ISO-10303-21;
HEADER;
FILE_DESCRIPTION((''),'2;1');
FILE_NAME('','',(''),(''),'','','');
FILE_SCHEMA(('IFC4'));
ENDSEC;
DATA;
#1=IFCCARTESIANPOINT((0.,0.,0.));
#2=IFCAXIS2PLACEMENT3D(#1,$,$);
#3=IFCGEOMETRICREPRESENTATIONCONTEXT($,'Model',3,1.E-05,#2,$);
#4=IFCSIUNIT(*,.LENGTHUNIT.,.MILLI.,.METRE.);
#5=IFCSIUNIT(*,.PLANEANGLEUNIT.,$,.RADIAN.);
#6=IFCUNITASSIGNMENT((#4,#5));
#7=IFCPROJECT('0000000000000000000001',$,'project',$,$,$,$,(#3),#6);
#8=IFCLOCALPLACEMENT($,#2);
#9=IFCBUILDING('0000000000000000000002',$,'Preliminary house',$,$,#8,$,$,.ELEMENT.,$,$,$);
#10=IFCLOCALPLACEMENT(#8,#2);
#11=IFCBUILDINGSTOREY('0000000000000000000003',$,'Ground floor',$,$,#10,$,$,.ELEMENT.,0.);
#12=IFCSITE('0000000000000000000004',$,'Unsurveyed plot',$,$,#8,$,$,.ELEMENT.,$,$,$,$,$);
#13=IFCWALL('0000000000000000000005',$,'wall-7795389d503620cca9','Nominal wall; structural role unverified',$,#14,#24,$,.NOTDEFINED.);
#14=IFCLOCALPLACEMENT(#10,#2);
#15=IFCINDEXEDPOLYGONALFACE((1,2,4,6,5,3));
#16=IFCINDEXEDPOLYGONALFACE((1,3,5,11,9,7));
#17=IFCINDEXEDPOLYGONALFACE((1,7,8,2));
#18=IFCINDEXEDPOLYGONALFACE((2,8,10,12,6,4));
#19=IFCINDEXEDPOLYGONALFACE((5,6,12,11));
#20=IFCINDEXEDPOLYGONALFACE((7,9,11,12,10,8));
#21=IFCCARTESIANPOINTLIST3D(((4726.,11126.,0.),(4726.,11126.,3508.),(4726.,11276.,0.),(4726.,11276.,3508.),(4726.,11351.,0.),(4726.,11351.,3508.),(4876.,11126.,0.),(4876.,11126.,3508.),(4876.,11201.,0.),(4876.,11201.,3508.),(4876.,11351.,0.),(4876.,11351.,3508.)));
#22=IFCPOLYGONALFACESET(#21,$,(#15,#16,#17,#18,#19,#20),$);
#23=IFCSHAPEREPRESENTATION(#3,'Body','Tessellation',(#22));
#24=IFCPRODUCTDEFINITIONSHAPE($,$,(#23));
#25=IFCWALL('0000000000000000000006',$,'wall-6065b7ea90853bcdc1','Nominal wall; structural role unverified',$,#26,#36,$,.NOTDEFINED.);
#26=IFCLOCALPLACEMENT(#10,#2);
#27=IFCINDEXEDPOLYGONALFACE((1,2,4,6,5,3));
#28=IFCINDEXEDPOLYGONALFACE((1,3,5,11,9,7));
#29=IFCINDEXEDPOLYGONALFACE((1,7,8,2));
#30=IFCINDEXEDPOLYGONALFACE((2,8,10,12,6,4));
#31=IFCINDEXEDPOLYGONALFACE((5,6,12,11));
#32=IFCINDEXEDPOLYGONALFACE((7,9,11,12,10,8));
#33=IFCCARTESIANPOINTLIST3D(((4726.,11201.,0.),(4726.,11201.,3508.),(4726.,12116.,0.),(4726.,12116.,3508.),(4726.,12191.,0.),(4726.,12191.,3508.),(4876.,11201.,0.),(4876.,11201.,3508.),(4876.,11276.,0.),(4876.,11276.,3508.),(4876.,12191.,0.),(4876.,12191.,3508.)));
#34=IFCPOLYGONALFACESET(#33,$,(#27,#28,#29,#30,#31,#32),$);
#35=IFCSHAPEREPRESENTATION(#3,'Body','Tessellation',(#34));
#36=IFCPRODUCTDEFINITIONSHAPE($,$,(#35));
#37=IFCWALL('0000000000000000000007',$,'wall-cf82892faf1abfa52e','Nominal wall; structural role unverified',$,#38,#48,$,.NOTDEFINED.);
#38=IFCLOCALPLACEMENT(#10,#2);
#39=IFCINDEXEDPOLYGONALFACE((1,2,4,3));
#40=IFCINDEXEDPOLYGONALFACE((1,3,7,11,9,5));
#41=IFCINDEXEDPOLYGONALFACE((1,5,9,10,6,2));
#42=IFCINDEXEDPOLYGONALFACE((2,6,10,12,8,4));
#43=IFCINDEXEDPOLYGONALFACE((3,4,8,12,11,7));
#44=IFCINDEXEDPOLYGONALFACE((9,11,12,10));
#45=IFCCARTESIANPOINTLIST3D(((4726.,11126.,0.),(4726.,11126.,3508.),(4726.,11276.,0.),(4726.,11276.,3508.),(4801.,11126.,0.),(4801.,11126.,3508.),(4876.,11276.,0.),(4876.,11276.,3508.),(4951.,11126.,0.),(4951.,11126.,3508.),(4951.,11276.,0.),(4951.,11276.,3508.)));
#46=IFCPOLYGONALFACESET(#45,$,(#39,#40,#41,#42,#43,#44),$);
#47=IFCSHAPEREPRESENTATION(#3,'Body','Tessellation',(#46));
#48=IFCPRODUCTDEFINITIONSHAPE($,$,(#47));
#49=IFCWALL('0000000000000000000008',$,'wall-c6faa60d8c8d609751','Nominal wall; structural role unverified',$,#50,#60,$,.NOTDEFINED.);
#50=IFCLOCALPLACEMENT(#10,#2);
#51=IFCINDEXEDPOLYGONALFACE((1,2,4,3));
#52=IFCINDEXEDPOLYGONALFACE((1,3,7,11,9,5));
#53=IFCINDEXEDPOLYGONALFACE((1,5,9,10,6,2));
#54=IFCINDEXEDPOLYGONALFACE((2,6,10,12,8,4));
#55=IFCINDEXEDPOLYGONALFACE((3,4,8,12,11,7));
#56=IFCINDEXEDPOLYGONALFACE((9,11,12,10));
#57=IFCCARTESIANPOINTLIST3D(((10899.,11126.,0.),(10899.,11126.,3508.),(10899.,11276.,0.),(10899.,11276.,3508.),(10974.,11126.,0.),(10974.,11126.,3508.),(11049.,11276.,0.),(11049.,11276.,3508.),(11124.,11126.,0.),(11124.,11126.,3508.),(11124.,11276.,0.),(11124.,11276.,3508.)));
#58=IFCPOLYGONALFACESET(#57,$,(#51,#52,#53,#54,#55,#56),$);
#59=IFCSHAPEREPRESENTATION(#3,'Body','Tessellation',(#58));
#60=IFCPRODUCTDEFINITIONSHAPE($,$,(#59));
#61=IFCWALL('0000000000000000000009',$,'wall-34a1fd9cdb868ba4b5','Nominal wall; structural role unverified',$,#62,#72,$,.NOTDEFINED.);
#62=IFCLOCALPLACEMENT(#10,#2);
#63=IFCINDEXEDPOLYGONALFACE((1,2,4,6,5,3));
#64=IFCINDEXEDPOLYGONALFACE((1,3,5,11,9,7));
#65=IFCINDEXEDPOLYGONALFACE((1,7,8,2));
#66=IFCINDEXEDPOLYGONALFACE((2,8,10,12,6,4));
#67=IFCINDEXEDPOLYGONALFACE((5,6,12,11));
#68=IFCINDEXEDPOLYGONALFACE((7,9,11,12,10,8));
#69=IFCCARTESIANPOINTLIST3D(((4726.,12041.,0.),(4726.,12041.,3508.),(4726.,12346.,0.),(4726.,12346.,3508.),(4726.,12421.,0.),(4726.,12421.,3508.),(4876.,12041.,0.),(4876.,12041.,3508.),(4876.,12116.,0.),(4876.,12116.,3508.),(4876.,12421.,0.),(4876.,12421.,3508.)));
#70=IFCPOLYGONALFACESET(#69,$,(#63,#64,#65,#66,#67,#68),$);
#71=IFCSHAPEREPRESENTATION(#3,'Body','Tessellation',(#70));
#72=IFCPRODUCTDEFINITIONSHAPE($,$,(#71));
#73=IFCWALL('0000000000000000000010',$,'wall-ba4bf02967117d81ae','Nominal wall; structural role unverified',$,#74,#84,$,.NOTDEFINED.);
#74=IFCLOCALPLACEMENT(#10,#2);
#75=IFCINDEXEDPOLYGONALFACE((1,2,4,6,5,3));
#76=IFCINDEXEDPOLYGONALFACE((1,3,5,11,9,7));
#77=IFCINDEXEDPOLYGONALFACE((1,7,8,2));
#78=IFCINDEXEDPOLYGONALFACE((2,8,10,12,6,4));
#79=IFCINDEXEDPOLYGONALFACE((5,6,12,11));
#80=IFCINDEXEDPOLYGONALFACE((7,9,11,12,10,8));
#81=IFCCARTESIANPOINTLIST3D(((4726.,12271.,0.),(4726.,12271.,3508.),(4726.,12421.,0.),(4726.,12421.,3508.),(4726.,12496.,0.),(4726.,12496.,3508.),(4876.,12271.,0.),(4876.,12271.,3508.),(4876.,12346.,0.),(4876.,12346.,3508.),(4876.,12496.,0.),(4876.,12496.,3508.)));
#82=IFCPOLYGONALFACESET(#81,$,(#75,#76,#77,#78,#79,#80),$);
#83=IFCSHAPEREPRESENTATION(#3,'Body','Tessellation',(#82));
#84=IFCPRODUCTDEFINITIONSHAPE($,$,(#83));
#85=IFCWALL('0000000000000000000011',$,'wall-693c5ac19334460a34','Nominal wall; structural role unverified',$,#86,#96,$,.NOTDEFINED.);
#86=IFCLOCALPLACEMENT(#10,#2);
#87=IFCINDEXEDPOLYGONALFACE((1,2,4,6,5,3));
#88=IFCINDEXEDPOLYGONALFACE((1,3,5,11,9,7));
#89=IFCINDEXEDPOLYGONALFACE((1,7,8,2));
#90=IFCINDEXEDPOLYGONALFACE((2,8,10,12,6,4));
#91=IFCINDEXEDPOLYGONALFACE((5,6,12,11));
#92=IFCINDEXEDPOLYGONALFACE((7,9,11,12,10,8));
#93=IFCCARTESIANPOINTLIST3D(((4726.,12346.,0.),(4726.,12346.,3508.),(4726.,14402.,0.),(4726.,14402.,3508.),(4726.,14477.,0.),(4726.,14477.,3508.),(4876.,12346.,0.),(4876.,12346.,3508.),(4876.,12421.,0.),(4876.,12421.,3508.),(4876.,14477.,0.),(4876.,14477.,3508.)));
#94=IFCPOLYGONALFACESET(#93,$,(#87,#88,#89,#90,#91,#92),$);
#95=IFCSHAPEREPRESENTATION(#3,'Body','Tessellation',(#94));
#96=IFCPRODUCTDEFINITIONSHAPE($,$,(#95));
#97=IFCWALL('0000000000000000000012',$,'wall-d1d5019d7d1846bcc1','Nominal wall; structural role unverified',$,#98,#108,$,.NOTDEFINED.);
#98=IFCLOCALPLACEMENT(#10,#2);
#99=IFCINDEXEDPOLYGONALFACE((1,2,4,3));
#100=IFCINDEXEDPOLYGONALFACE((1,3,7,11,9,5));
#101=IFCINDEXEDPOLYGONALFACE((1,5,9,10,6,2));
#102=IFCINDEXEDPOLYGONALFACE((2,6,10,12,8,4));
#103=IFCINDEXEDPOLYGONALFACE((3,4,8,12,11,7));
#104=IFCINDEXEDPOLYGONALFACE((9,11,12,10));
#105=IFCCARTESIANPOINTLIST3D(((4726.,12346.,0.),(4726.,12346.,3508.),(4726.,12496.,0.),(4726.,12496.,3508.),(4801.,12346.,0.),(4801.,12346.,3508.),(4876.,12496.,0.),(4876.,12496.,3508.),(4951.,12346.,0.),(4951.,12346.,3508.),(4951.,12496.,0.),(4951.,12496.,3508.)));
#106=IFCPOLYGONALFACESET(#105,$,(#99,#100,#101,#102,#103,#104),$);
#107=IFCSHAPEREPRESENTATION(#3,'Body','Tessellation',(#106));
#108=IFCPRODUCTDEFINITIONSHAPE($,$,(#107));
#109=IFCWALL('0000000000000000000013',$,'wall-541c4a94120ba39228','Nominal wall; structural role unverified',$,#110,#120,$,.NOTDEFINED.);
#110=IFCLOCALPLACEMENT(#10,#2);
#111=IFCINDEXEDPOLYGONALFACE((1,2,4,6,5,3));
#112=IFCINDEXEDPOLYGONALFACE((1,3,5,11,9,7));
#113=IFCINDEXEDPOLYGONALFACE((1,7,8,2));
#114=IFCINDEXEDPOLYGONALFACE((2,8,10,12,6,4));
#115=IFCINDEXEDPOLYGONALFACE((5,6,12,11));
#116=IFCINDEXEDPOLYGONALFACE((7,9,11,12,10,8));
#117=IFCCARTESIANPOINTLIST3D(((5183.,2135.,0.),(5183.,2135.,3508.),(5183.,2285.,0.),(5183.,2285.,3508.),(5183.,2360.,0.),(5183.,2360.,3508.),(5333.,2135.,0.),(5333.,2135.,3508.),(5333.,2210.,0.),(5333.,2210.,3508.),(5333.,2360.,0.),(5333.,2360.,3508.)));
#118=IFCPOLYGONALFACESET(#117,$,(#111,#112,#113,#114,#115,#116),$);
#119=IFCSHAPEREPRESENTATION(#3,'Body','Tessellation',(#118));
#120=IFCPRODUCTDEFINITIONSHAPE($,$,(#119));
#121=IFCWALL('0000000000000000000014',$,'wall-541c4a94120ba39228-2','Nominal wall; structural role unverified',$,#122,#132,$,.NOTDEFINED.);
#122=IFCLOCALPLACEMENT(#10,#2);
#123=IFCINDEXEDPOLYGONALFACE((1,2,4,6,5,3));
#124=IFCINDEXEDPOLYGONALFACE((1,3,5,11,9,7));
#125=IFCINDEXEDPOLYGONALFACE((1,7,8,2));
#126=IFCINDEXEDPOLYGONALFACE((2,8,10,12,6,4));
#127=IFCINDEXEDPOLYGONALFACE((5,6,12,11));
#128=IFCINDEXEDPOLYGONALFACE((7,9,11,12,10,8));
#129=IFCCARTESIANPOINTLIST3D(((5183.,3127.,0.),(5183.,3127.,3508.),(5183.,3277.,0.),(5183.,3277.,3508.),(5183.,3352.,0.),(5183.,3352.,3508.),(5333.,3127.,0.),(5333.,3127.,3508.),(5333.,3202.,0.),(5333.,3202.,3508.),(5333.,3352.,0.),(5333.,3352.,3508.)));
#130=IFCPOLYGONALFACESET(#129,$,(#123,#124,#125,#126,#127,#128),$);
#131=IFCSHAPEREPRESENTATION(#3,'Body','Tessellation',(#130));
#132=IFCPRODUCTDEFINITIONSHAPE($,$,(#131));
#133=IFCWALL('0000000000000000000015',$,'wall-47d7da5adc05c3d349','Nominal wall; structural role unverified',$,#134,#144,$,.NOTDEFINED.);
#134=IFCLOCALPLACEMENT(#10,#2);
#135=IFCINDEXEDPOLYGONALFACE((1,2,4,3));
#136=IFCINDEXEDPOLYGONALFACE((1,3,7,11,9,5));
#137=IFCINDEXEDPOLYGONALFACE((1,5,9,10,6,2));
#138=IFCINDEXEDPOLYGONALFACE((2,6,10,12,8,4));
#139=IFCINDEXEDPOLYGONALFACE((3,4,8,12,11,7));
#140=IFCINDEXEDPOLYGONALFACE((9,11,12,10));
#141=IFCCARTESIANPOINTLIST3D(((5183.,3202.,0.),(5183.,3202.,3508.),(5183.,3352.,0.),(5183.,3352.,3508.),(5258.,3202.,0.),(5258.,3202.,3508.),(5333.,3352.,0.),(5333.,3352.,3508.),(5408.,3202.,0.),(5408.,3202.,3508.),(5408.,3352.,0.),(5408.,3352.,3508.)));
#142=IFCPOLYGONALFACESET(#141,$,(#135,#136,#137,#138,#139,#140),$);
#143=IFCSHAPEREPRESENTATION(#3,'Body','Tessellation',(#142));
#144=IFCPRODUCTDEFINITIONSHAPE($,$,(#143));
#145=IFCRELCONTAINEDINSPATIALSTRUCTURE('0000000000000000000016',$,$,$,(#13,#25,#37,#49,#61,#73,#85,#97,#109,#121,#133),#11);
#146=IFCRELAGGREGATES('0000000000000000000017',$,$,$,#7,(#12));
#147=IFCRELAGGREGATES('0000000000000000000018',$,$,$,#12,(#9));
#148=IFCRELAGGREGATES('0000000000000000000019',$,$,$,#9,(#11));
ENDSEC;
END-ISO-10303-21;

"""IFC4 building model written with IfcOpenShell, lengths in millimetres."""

from ifc_helpers import new_model, si_unit, origin, place, context, project, spatial, polyline, outline, extrude, element, save


model = new_model("IFC4")

# Units and contexts
model_context = context("Model", 3, precision=1e-05, world=origin())
ifc_project = project(units=[si_unit("LENGTHUNIT", "METRE", prefix="MILLI"), si_unit("PLANEANGLEUNIT", "RADIAN")], contexts=[model_context])

# Site, building, storey
placement_1 = place(None, origin())
site = spatial("IfcSite", under=ifc_project, at=placement_1, Name="Unsurveyed plot", CompositionType="ELEMENT")
building = spatial("IfcBuilding", under=site, at=placement_1, Name="Preliminary house", CompositionType="ELEMENT")
placement_2 = place(placement_1, origin())
storey = spatial("IfcBuildingStorey", under=building, at=placement_2, Name="Ground floor", CompositionType="ELEMENT", Elevation=0.0)

# Walls
element("IfcWall", 1, at=placement_2, inside=storey, Name="wall-7795389d503620cca9", Description="Nominal wall; structural role unverified", PredefinedType="NOTDEFINED", context=model_context, shape_type="SweptSolid", body=[
    extrude(outline(polyline([(4726.0, 11276.0), (4726.0, 11351.0), (4876.0, 11351.0), (4876.0, 11201.0), (4876.0, 11126.0), (4726.0, 11126.0), (4726.0, 11276.0)])), origin(), (0.0, 0.0, 1.0), 3508.0),
])
element("IfcWall", 2, at=placement_2, inside=storey, Name="wall-6065b7ea90853bcdc1", Description="Nominal wall; structural role unverified", PredefinedType="NOTDEFINED", context=model_context, shape_type="SweptSolid", body=[
    extrude(outline(polyline([(4726.0, 12116.0), (4726.0, 12191.0), (4876.0, 12191.0), (4876.0, 11276.0), (4876.0, 11201.0), (4726.0, 11201.0), (4726.0, 12116.0)])), origin(), (0.0, 0.0, 1.0), 3508.0),
])
element("IfcWall", 3, at=placement_2, inside=storey, Name="wall-cf82892faf1abfa52e", Description="Nominal wall; structural role unverified", PredefinedType="NOTDEFINED", context=model_context, shape_type="SweptSolid", body=[
    extrude(outline(polyline([(4876.0, 11276.0), (4951.0, 11276.0), (4951.0, 11126.0), (4801.0, 11126.0), (4726.0, 11126.0), (4726.0, 11276.0), (4876.0, 11276.0)])), origin(), (0.0, 0.0, 1.0), 3508.0),
])

# Walls
element("IfcWall", 4, at=placement_2, inside=storey, Name="wall-c6faa60d8c8d609751", Description="Nominal wall; structural role unverified", PredefinedType="NOTDEFINED", context=model_context, shape_type="SweptSolid", body=[
    extrude(outline(polyline([(11049.0, 11276.0), (11124.0, 11276.0), (11124.0, 11126.0), (10974.0, 11126.0), (10899.0, 11126.0), (10899.0, 11276.0), (11049.0, 11276.0)])), origin(), (0.0, 0.0, 1.0), 3508.0),
])
element("IfcWall", 5, at=placement_2, inside=storey, Name="wall-34a1fd9cdb868ba4b5", Description="Nominal wall; structural role unverified", PredefinedType="NOTDEFINED", context=model_context, shape_type="SweptSolid", body=[
    extrude(outline(polyline([(4726.0, 12346.0), (4726.0, 12421.0), (4876.0, 12421.0), (4876.0, 12116.0), (4876.0, 12041.0), (4726.0, 12041.0), (4726.0, 12346.0)])), origin(), (0.0, 0.0, 1.0), 3508.0),
])
element("IfcWall", 6, at=placement_2, inside=storey, Name="wall-ba4bf02967117d81ae", Description="Nominal wall; structural role unverified", PredefinedType="NOTDEFINED", context=model_context, shape_type="SweptSolid", body=[
    extrude(outline(polyline([(4726.0, 12421.0), (4726.0, 12496.0), (4876.0, 12496.0), (4876.0, 12346.0), (4876.0, 12271.0), (4726.0, 12271.0), (4726.0, 12421.0)])), origin(), (0.0, 0.0, 1.0), 3508.0),
])
element("IfcWall", 7, at=placement_2, inside=storey, Name="wall-693c5ac19334460a34", Description="Nominal wall; structural role unverified", PredefinedType="NOTDEFINED", context=model_context, shape_type="SweptSolid", body=[
    extrude(outline(polyline([(4726.0, 14402.0), (4726.0, 14477.0), (4876.0, 14477.0), (4876.0, 12421.0), (4876.0, 12346.0), (4726.0, 12346.0), (4726.0, 14402.0)])), origin(), (0.0, 0.0, 1.0), 3508.0),
])
element("IfcWall", 8, at=placement_2, inside=storey, Name="wall-d1d5019d7d1846bcc1", Description="Nominal wall; structural role unverified", PredefinedType="NOTDEFINED", context=model_context, shape_type="SweptSolid", body=[
    extrude(outline(polyline([(4876.0, 12496.0), (4951.0, 12496.0), (4951.0, 12346.0), (4801.0, 12346.0), (4726.0, 12346.0), (4726.0, 12496.0), (4876.0, 12496.0)])), origin(), (0.0, 0.0, 1.0), 3508.0),
])

# Wall
element("IfcWall", 9, at=placement_2, inside=storey, Name="wall-541c4a94120ba39228", Description="Nominal wall; structural role unverified", PredefinedType="NOTDEFINED", context=model_context, shape_type="SweptSolid", body=[
    extrude(outline(polyline([(5183.0, 2285.0), (5183.0, 2360.0), (5333.0, 2360.0), (5333.0, 2210.0), (5333.0, 2135.0), (5183.0, 2135.0), (5183.0, 2285.0)])), origin(), (0.0, 0.0, 1.0), 3508.0),
])

# Wall
element("IfcWall", 10, at=placement_2, inside=storey, Name="wall-541c4a94120ba39228-2", Description="Nominal wall; structural role unverified", PredefinedType="NOTDEFINED", context=model_context, shape_type="SweptSolid", body=[
    extrude(outline(polyline([(5183.0, 3277.0), (5183.0, 3352.0), (5333.0, 3352.0), (5333.0, 3202.0), (5333.0, 3127.0), (5183.0, 3127.0), (5183.0, 3277.0)])), origin(), (0.0, 0.0, 1.0), 3508.0),
])

# Wall
element("IfcWall", 11, at=placement_2, inside=storey, Name="wall-47d7da5adc05c3d349", Description="Nominal wall; structural role unverified", PredefinedType="NOTDEFINED", context=model_context, shape_type="SweptSolid", body=[
    extrude(outline(polyline([(5333.0, 3352.0), (5408.0, 3352.0), (5408.0, 3202.0), (5258.0, 3202.0), (5183.0, 3202.0), (5183.0, 3352.0), (5333.0, 3352.0)])), origin(), (0.0, 0.0, 1.0), 3508.0),
])

save(model, "model.ifc")
